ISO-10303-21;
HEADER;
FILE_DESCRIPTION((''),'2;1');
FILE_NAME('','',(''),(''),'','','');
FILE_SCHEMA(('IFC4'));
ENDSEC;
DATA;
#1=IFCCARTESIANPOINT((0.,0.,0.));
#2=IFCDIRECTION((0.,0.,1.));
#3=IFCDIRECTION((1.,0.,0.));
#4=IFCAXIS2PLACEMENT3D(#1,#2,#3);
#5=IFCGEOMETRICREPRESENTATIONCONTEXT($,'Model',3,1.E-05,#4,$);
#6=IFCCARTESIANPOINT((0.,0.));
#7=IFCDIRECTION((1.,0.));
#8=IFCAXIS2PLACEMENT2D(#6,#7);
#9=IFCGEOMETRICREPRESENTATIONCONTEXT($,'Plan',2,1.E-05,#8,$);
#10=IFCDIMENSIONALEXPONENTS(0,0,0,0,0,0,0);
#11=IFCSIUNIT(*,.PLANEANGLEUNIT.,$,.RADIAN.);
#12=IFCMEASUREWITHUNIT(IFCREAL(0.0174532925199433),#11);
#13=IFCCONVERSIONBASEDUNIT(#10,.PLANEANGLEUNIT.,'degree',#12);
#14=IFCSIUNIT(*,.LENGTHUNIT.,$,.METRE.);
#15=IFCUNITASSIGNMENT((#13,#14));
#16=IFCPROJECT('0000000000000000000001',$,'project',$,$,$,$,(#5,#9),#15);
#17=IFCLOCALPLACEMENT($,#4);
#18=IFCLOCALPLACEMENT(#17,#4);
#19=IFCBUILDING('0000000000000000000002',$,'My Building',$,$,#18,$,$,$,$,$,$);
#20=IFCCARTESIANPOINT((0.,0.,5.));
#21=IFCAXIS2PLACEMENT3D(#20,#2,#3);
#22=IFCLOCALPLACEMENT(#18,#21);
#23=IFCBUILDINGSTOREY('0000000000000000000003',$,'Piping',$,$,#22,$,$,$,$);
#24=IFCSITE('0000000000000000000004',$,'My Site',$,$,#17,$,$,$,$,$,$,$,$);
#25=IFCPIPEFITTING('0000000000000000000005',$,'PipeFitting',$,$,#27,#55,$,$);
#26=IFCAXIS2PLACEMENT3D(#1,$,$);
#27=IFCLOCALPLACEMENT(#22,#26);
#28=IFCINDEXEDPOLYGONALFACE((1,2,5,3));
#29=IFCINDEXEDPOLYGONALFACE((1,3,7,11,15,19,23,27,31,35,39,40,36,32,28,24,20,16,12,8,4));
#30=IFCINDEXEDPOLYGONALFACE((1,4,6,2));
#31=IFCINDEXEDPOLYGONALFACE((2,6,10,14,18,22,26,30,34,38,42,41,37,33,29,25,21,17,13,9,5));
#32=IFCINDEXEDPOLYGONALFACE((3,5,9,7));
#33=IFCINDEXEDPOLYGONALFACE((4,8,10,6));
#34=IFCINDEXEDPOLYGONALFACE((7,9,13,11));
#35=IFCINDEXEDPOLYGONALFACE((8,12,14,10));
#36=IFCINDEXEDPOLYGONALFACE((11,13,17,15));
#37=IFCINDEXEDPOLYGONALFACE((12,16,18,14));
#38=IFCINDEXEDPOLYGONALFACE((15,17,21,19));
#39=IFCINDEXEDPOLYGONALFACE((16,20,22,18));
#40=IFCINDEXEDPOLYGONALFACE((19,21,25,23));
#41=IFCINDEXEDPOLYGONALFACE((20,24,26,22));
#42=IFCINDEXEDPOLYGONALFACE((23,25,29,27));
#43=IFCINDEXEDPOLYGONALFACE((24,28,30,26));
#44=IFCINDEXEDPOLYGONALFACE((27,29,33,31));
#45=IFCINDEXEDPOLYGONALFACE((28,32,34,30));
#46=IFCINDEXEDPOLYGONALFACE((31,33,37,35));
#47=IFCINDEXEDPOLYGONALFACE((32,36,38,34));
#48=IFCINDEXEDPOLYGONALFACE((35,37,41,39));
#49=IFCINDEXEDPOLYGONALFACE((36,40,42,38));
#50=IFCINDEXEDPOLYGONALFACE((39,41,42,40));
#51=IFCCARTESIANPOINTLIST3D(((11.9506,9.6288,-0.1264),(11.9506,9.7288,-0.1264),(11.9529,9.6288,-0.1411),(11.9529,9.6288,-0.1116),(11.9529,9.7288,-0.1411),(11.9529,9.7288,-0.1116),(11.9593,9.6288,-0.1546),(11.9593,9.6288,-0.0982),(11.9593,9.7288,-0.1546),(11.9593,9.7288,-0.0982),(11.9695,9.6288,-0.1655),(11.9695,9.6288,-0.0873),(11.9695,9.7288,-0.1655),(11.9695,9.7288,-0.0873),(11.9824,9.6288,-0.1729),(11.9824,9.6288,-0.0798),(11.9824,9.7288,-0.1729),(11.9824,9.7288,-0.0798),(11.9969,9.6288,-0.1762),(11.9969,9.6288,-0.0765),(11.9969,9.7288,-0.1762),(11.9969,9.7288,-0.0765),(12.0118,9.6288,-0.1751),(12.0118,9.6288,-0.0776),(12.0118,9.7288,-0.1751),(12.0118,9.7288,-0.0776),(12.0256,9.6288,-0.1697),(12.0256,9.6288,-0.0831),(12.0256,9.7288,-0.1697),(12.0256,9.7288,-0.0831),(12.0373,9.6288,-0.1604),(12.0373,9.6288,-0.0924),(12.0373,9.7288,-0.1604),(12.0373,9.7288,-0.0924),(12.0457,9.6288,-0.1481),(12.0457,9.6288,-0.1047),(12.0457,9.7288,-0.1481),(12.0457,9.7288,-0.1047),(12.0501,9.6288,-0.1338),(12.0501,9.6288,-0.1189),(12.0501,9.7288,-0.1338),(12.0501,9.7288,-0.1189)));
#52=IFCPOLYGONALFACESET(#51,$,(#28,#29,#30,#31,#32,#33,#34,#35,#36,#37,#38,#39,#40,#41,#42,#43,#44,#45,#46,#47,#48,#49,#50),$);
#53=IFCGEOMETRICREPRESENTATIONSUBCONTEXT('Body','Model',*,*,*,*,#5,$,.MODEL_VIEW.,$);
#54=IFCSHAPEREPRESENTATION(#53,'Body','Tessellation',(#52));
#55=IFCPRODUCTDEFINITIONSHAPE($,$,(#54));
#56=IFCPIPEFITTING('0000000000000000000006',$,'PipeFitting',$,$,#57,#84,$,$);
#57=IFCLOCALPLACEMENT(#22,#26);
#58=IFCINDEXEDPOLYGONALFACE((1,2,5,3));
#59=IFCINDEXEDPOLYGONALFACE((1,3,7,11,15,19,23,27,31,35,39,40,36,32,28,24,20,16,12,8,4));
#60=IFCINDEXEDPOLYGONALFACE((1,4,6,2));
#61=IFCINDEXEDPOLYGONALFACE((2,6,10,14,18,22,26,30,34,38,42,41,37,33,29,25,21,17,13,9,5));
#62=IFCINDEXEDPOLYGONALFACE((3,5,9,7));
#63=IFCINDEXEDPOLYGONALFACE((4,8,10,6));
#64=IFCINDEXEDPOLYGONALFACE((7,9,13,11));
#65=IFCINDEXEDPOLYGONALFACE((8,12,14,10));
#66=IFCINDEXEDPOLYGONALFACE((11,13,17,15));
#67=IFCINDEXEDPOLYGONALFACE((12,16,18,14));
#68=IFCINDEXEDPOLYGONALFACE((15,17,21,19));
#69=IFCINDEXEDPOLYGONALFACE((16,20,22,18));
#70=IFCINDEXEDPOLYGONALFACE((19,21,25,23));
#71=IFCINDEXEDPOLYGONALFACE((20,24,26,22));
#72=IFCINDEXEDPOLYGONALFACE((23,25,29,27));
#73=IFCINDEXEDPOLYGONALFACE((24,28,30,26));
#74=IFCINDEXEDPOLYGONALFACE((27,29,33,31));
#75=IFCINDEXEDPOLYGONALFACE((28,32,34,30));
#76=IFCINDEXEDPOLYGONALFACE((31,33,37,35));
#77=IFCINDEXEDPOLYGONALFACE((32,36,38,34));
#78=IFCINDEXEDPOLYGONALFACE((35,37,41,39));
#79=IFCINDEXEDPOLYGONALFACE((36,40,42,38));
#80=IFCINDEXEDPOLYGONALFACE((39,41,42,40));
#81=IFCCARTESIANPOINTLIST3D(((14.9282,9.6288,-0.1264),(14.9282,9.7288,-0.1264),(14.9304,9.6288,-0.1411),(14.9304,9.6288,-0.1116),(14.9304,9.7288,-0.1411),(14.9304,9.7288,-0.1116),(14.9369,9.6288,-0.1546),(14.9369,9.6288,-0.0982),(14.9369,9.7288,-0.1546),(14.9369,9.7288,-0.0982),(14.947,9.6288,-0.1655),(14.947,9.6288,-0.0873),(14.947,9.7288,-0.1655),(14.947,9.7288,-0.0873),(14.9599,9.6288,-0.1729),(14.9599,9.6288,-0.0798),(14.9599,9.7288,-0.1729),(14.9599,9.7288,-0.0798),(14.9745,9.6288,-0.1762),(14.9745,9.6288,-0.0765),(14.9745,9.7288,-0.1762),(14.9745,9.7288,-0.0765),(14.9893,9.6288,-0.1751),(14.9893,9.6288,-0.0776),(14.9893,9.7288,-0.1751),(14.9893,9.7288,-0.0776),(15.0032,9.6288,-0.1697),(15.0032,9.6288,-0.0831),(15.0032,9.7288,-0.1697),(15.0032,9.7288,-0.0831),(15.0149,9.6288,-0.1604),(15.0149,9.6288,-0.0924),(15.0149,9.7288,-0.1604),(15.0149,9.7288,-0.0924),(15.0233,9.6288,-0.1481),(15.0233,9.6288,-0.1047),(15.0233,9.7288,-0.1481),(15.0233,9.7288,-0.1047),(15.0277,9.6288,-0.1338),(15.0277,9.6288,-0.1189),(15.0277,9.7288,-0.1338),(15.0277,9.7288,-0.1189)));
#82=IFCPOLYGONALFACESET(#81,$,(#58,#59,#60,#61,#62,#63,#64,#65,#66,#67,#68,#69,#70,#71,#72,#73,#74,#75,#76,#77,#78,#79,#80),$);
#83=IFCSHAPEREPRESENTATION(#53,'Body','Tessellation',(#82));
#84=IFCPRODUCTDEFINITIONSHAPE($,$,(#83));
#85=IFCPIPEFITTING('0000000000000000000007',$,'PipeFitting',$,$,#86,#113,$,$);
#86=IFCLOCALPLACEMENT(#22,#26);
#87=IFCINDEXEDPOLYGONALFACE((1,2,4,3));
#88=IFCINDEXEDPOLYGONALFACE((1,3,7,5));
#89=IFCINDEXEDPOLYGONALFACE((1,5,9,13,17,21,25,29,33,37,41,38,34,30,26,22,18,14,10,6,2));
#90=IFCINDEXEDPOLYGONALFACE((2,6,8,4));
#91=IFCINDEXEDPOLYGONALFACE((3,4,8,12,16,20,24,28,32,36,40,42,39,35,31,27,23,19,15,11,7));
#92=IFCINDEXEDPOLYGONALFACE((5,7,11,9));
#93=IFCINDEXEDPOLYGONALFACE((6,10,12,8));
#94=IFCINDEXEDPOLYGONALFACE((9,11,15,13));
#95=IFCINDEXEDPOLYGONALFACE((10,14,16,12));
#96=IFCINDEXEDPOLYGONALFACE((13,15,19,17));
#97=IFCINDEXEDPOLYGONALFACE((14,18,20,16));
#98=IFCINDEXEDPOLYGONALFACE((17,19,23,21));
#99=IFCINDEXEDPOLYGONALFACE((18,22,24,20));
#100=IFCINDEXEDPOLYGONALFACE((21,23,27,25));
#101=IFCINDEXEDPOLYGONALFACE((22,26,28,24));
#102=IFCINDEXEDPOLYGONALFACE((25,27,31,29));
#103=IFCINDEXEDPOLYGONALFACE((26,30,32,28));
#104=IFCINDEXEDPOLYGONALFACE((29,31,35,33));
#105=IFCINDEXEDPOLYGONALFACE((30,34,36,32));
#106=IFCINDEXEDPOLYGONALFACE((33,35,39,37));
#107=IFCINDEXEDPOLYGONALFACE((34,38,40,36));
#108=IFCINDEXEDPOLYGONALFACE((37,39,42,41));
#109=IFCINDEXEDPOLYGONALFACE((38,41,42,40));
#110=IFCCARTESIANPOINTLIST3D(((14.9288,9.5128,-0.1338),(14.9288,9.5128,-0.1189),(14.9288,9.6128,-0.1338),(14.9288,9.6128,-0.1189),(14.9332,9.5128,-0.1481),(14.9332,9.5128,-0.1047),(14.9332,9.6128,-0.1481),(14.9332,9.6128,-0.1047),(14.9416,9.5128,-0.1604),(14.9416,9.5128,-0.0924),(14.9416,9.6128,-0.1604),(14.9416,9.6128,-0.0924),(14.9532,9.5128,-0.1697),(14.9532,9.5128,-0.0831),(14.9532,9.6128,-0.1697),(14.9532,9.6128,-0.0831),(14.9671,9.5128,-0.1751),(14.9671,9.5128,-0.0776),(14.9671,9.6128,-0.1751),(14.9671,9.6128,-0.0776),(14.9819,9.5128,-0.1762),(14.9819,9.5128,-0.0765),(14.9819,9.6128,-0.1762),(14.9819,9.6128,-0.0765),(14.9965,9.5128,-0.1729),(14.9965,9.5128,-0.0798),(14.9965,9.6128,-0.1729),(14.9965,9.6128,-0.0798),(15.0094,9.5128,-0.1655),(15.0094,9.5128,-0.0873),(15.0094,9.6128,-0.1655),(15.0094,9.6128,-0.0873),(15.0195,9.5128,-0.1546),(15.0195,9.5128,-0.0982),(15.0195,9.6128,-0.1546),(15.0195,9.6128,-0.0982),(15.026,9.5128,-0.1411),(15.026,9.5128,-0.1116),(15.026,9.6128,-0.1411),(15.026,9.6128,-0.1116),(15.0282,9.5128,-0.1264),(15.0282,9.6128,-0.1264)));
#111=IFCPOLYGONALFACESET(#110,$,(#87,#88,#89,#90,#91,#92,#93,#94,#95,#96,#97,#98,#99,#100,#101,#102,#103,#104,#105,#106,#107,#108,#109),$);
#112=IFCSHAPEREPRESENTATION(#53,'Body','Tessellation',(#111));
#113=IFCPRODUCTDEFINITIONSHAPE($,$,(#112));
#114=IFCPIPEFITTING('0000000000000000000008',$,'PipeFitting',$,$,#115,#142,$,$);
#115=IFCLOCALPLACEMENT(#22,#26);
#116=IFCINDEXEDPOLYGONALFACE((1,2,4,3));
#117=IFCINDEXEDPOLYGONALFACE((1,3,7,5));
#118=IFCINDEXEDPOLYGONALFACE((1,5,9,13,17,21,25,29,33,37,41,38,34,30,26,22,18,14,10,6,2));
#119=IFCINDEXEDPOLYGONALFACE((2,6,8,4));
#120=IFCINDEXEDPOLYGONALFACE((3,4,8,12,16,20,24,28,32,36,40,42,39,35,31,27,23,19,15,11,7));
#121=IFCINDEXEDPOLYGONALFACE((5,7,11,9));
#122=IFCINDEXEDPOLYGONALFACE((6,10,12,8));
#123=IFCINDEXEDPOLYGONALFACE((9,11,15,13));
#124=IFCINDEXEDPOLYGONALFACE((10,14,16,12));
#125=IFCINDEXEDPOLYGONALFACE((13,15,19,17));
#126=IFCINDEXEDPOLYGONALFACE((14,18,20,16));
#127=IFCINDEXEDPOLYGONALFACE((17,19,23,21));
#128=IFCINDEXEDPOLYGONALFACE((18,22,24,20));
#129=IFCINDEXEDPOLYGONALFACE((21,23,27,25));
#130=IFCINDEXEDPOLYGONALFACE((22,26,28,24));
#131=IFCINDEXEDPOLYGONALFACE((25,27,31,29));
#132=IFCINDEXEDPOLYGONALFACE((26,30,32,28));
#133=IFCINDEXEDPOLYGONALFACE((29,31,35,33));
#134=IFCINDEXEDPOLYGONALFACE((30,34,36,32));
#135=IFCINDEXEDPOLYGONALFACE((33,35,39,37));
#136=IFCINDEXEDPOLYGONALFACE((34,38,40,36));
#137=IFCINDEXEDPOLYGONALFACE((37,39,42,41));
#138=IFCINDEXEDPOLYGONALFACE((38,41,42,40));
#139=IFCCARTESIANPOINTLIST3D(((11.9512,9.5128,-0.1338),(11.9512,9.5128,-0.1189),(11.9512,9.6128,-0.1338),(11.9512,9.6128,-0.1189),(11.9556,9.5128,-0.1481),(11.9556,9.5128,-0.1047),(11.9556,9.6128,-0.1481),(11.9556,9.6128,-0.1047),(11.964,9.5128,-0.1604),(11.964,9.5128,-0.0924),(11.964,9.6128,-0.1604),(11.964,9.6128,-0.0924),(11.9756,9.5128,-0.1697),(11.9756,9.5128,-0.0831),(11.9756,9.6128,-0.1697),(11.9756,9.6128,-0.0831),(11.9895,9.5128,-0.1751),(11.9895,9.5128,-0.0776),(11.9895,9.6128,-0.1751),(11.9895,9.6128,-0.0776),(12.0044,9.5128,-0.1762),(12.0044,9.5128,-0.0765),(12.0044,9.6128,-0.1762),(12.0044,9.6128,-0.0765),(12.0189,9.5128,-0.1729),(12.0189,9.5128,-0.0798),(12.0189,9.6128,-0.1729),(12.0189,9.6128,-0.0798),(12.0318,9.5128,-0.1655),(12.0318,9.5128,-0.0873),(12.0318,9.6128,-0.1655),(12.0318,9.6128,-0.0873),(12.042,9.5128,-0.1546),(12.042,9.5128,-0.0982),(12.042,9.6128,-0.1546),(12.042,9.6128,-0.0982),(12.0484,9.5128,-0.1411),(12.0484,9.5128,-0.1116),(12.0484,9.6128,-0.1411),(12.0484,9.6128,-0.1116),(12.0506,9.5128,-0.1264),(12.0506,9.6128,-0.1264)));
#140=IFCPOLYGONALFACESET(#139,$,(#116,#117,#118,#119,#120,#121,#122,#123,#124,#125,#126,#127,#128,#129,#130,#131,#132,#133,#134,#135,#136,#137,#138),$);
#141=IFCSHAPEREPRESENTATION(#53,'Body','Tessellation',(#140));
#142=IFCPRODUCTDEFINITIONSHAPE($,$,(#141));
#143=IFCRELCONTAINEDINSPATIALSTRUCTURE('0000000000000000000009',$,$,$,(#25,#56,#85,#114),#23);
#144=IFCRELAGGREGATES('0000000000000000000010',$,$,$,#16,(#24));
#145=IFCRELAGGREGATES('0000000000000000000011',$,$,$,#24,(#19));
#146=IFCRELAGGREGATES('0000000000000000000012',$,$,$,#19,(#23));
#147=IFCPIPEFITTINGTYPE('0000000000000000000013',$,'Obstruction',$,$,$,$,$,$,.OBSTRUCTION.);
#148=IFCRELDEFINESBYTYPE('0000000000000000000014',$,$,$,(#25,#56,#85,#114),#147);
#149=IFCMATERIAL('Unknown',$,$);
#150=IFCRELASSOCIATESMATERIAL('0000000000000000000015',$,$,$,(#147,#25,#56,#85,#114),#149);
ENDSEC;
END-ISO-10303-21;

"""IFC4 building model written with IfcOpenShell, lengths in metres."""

from ifc_helpers import new_model, entity, si_unit, converted_unit, frame, origin_with_axes, origin_2d_with_axis, place, context, subcontext, project, spatial, circle, extrude, material, material_profile, profile_set, profile_usage, type_object, element, save


model = new_model("IFC4")

# Units and contexts
model_context = context("Model", 3, precision=1e-05, world=origin_with_axes())
plan_context = context("Plan", 2, precision=1e-05, world=origin_2d_with_axis())
body_context = subcontext(model_context, "Body", "Model", "MODEL_VIEW")
ifc_project = project(units=[converted_unit("PLANEANGLEUNIT", "degree", entity("IfcReal", 0.0174532925199433), si_unit("PLANEANGLEUNIT", "RADIAN"), dimensions=[0, 0, 0, 0, 0, 0, 0]), si_unit("LENGTHUNIT", "METRE")], contexts=[model_context, plan_context])

# Site, building, storey
site_placement = place(None, origin_with_axes())
site = spatial("IfcSite", under=ifc_project, at=site_placement, Name="My Site")
building_placement = place(site_placement, origin_with_axes())
building = spatial("IfcBuilding", under=site, at=building_placement, Name="My Building")
storey_placement = place(building_placement, frame((0.0, 0.0, 5.0), z_axis=(0.0, 0.0, 1.0), x_axis=(1.0, 0.0, 0.0)))
storey = spatial("IfcBuildingStorey", under=building, at=storey_placement, Name="Piping")

# Shared definitions
ifc_material = material(Name="Unknown")

# Pipe fittings
ifc_material_profile_1 = material_profile(ifc_material, circle(Radius=0.05))
ifc_profile_set_1 = profile_set([ifc_material_profile_1])
pipe_fitting_type_1 = type_object("IfcPipeFittingType", Name="Obstruction", PredefinedType="OBSTRUCTION", material=ifc_profile_set_1)
ifc_profile_usage_1 = profile_usage(ifc_profile_set_1, cardinal=5)
pipe_fitting_1_placement = place(storey_placement, frame((12.0006, 9.6288, -0.1264), z_axis=(0.0, 1.0, 0.0), x_axis=(-1.0, 0.0, 0.0)))
element("IfcPipeFitting", 1, at=pipe_fitting_1_placement, inside=storey, type_object=pipe_fitting_type_1, material=ifc_profile_usage_1, Name="PipeFitting", context=body_context, shape_type="SweptSolid", body=[
    extrude(circle(Radius=0.05), origin_with_axes(), (0.0, 0.0, 1.0), 0.1),
])
ifc_profile_usage_2 = profile_usage(ifc_profile_set_1, cardinal=5)
pipe_fitting_2_placement = place(storey_placement, frame((14.9782, 9.6288, -0.1264), z_axis=(0.0, 1.0, 0.0), x_axis=(-1.0, 0.0, 0.0)))
element("IfcPipeFitting", 2, at=pipe_fitting_2_placement, inside=storey, type_object=pipe_fitting_type_1, material=ifc_profile_usage_2, Name="PipeFitting", context=body_context, shape_type="SweptSolid", body=[
    extrude(circle(Radius=0.05), origin_with_axes(), (0.0, 0.0, 1.0), 0.1),
])
ifc_profile_usage_3 = profile_usage(ifc_profile_set_1, cardinal=5)
pipe_fitting_3_placement = place(storey_placement, frame((14.9782, 9.6128, -0.1264), z_axis=(0.0, -1.0, 0.0), x_axis=(1.0, 0.0, 0.0)))
element("IfcPipeFitting", 3, at=pipe_fitting_3_placement, inside=storey, type_object=pipe_fitting_type_1, material=ifc_profile_usage_3, Name="PipeFitting", context=body_context, shape_type="SweptSolid", body=[
    extrude(circle(Radius=0.05), origin_with_axes(), (0.0, 0.0, 1.0), 0.1),
])
ifc_profile_usage_4 = profile_usage(ifc_profile_set_1, cardinal=5)
pipe_fitting_4_placement = place(storey_placement, frame((12.0006, 9.6128, -0.1264), z_axis=(0.0, -1.0, 0.0), x_axis=(1.0, 0.0, 0.0)))
element("IfcPipeFitting", 4, at=pipe_fitting_4_placement, inside=storey, type_object=pipe_fitting_type_1, material=ifc_profile_usage_4, Name="PipeFitting", context=body_context, shape_type="SweptSolid", body=[
    extrude(circle(Radius=0.05), origin_with_axes(), (0.0, 0.0, 1.0), 0.1),
])

save(model, "model.ifc")
